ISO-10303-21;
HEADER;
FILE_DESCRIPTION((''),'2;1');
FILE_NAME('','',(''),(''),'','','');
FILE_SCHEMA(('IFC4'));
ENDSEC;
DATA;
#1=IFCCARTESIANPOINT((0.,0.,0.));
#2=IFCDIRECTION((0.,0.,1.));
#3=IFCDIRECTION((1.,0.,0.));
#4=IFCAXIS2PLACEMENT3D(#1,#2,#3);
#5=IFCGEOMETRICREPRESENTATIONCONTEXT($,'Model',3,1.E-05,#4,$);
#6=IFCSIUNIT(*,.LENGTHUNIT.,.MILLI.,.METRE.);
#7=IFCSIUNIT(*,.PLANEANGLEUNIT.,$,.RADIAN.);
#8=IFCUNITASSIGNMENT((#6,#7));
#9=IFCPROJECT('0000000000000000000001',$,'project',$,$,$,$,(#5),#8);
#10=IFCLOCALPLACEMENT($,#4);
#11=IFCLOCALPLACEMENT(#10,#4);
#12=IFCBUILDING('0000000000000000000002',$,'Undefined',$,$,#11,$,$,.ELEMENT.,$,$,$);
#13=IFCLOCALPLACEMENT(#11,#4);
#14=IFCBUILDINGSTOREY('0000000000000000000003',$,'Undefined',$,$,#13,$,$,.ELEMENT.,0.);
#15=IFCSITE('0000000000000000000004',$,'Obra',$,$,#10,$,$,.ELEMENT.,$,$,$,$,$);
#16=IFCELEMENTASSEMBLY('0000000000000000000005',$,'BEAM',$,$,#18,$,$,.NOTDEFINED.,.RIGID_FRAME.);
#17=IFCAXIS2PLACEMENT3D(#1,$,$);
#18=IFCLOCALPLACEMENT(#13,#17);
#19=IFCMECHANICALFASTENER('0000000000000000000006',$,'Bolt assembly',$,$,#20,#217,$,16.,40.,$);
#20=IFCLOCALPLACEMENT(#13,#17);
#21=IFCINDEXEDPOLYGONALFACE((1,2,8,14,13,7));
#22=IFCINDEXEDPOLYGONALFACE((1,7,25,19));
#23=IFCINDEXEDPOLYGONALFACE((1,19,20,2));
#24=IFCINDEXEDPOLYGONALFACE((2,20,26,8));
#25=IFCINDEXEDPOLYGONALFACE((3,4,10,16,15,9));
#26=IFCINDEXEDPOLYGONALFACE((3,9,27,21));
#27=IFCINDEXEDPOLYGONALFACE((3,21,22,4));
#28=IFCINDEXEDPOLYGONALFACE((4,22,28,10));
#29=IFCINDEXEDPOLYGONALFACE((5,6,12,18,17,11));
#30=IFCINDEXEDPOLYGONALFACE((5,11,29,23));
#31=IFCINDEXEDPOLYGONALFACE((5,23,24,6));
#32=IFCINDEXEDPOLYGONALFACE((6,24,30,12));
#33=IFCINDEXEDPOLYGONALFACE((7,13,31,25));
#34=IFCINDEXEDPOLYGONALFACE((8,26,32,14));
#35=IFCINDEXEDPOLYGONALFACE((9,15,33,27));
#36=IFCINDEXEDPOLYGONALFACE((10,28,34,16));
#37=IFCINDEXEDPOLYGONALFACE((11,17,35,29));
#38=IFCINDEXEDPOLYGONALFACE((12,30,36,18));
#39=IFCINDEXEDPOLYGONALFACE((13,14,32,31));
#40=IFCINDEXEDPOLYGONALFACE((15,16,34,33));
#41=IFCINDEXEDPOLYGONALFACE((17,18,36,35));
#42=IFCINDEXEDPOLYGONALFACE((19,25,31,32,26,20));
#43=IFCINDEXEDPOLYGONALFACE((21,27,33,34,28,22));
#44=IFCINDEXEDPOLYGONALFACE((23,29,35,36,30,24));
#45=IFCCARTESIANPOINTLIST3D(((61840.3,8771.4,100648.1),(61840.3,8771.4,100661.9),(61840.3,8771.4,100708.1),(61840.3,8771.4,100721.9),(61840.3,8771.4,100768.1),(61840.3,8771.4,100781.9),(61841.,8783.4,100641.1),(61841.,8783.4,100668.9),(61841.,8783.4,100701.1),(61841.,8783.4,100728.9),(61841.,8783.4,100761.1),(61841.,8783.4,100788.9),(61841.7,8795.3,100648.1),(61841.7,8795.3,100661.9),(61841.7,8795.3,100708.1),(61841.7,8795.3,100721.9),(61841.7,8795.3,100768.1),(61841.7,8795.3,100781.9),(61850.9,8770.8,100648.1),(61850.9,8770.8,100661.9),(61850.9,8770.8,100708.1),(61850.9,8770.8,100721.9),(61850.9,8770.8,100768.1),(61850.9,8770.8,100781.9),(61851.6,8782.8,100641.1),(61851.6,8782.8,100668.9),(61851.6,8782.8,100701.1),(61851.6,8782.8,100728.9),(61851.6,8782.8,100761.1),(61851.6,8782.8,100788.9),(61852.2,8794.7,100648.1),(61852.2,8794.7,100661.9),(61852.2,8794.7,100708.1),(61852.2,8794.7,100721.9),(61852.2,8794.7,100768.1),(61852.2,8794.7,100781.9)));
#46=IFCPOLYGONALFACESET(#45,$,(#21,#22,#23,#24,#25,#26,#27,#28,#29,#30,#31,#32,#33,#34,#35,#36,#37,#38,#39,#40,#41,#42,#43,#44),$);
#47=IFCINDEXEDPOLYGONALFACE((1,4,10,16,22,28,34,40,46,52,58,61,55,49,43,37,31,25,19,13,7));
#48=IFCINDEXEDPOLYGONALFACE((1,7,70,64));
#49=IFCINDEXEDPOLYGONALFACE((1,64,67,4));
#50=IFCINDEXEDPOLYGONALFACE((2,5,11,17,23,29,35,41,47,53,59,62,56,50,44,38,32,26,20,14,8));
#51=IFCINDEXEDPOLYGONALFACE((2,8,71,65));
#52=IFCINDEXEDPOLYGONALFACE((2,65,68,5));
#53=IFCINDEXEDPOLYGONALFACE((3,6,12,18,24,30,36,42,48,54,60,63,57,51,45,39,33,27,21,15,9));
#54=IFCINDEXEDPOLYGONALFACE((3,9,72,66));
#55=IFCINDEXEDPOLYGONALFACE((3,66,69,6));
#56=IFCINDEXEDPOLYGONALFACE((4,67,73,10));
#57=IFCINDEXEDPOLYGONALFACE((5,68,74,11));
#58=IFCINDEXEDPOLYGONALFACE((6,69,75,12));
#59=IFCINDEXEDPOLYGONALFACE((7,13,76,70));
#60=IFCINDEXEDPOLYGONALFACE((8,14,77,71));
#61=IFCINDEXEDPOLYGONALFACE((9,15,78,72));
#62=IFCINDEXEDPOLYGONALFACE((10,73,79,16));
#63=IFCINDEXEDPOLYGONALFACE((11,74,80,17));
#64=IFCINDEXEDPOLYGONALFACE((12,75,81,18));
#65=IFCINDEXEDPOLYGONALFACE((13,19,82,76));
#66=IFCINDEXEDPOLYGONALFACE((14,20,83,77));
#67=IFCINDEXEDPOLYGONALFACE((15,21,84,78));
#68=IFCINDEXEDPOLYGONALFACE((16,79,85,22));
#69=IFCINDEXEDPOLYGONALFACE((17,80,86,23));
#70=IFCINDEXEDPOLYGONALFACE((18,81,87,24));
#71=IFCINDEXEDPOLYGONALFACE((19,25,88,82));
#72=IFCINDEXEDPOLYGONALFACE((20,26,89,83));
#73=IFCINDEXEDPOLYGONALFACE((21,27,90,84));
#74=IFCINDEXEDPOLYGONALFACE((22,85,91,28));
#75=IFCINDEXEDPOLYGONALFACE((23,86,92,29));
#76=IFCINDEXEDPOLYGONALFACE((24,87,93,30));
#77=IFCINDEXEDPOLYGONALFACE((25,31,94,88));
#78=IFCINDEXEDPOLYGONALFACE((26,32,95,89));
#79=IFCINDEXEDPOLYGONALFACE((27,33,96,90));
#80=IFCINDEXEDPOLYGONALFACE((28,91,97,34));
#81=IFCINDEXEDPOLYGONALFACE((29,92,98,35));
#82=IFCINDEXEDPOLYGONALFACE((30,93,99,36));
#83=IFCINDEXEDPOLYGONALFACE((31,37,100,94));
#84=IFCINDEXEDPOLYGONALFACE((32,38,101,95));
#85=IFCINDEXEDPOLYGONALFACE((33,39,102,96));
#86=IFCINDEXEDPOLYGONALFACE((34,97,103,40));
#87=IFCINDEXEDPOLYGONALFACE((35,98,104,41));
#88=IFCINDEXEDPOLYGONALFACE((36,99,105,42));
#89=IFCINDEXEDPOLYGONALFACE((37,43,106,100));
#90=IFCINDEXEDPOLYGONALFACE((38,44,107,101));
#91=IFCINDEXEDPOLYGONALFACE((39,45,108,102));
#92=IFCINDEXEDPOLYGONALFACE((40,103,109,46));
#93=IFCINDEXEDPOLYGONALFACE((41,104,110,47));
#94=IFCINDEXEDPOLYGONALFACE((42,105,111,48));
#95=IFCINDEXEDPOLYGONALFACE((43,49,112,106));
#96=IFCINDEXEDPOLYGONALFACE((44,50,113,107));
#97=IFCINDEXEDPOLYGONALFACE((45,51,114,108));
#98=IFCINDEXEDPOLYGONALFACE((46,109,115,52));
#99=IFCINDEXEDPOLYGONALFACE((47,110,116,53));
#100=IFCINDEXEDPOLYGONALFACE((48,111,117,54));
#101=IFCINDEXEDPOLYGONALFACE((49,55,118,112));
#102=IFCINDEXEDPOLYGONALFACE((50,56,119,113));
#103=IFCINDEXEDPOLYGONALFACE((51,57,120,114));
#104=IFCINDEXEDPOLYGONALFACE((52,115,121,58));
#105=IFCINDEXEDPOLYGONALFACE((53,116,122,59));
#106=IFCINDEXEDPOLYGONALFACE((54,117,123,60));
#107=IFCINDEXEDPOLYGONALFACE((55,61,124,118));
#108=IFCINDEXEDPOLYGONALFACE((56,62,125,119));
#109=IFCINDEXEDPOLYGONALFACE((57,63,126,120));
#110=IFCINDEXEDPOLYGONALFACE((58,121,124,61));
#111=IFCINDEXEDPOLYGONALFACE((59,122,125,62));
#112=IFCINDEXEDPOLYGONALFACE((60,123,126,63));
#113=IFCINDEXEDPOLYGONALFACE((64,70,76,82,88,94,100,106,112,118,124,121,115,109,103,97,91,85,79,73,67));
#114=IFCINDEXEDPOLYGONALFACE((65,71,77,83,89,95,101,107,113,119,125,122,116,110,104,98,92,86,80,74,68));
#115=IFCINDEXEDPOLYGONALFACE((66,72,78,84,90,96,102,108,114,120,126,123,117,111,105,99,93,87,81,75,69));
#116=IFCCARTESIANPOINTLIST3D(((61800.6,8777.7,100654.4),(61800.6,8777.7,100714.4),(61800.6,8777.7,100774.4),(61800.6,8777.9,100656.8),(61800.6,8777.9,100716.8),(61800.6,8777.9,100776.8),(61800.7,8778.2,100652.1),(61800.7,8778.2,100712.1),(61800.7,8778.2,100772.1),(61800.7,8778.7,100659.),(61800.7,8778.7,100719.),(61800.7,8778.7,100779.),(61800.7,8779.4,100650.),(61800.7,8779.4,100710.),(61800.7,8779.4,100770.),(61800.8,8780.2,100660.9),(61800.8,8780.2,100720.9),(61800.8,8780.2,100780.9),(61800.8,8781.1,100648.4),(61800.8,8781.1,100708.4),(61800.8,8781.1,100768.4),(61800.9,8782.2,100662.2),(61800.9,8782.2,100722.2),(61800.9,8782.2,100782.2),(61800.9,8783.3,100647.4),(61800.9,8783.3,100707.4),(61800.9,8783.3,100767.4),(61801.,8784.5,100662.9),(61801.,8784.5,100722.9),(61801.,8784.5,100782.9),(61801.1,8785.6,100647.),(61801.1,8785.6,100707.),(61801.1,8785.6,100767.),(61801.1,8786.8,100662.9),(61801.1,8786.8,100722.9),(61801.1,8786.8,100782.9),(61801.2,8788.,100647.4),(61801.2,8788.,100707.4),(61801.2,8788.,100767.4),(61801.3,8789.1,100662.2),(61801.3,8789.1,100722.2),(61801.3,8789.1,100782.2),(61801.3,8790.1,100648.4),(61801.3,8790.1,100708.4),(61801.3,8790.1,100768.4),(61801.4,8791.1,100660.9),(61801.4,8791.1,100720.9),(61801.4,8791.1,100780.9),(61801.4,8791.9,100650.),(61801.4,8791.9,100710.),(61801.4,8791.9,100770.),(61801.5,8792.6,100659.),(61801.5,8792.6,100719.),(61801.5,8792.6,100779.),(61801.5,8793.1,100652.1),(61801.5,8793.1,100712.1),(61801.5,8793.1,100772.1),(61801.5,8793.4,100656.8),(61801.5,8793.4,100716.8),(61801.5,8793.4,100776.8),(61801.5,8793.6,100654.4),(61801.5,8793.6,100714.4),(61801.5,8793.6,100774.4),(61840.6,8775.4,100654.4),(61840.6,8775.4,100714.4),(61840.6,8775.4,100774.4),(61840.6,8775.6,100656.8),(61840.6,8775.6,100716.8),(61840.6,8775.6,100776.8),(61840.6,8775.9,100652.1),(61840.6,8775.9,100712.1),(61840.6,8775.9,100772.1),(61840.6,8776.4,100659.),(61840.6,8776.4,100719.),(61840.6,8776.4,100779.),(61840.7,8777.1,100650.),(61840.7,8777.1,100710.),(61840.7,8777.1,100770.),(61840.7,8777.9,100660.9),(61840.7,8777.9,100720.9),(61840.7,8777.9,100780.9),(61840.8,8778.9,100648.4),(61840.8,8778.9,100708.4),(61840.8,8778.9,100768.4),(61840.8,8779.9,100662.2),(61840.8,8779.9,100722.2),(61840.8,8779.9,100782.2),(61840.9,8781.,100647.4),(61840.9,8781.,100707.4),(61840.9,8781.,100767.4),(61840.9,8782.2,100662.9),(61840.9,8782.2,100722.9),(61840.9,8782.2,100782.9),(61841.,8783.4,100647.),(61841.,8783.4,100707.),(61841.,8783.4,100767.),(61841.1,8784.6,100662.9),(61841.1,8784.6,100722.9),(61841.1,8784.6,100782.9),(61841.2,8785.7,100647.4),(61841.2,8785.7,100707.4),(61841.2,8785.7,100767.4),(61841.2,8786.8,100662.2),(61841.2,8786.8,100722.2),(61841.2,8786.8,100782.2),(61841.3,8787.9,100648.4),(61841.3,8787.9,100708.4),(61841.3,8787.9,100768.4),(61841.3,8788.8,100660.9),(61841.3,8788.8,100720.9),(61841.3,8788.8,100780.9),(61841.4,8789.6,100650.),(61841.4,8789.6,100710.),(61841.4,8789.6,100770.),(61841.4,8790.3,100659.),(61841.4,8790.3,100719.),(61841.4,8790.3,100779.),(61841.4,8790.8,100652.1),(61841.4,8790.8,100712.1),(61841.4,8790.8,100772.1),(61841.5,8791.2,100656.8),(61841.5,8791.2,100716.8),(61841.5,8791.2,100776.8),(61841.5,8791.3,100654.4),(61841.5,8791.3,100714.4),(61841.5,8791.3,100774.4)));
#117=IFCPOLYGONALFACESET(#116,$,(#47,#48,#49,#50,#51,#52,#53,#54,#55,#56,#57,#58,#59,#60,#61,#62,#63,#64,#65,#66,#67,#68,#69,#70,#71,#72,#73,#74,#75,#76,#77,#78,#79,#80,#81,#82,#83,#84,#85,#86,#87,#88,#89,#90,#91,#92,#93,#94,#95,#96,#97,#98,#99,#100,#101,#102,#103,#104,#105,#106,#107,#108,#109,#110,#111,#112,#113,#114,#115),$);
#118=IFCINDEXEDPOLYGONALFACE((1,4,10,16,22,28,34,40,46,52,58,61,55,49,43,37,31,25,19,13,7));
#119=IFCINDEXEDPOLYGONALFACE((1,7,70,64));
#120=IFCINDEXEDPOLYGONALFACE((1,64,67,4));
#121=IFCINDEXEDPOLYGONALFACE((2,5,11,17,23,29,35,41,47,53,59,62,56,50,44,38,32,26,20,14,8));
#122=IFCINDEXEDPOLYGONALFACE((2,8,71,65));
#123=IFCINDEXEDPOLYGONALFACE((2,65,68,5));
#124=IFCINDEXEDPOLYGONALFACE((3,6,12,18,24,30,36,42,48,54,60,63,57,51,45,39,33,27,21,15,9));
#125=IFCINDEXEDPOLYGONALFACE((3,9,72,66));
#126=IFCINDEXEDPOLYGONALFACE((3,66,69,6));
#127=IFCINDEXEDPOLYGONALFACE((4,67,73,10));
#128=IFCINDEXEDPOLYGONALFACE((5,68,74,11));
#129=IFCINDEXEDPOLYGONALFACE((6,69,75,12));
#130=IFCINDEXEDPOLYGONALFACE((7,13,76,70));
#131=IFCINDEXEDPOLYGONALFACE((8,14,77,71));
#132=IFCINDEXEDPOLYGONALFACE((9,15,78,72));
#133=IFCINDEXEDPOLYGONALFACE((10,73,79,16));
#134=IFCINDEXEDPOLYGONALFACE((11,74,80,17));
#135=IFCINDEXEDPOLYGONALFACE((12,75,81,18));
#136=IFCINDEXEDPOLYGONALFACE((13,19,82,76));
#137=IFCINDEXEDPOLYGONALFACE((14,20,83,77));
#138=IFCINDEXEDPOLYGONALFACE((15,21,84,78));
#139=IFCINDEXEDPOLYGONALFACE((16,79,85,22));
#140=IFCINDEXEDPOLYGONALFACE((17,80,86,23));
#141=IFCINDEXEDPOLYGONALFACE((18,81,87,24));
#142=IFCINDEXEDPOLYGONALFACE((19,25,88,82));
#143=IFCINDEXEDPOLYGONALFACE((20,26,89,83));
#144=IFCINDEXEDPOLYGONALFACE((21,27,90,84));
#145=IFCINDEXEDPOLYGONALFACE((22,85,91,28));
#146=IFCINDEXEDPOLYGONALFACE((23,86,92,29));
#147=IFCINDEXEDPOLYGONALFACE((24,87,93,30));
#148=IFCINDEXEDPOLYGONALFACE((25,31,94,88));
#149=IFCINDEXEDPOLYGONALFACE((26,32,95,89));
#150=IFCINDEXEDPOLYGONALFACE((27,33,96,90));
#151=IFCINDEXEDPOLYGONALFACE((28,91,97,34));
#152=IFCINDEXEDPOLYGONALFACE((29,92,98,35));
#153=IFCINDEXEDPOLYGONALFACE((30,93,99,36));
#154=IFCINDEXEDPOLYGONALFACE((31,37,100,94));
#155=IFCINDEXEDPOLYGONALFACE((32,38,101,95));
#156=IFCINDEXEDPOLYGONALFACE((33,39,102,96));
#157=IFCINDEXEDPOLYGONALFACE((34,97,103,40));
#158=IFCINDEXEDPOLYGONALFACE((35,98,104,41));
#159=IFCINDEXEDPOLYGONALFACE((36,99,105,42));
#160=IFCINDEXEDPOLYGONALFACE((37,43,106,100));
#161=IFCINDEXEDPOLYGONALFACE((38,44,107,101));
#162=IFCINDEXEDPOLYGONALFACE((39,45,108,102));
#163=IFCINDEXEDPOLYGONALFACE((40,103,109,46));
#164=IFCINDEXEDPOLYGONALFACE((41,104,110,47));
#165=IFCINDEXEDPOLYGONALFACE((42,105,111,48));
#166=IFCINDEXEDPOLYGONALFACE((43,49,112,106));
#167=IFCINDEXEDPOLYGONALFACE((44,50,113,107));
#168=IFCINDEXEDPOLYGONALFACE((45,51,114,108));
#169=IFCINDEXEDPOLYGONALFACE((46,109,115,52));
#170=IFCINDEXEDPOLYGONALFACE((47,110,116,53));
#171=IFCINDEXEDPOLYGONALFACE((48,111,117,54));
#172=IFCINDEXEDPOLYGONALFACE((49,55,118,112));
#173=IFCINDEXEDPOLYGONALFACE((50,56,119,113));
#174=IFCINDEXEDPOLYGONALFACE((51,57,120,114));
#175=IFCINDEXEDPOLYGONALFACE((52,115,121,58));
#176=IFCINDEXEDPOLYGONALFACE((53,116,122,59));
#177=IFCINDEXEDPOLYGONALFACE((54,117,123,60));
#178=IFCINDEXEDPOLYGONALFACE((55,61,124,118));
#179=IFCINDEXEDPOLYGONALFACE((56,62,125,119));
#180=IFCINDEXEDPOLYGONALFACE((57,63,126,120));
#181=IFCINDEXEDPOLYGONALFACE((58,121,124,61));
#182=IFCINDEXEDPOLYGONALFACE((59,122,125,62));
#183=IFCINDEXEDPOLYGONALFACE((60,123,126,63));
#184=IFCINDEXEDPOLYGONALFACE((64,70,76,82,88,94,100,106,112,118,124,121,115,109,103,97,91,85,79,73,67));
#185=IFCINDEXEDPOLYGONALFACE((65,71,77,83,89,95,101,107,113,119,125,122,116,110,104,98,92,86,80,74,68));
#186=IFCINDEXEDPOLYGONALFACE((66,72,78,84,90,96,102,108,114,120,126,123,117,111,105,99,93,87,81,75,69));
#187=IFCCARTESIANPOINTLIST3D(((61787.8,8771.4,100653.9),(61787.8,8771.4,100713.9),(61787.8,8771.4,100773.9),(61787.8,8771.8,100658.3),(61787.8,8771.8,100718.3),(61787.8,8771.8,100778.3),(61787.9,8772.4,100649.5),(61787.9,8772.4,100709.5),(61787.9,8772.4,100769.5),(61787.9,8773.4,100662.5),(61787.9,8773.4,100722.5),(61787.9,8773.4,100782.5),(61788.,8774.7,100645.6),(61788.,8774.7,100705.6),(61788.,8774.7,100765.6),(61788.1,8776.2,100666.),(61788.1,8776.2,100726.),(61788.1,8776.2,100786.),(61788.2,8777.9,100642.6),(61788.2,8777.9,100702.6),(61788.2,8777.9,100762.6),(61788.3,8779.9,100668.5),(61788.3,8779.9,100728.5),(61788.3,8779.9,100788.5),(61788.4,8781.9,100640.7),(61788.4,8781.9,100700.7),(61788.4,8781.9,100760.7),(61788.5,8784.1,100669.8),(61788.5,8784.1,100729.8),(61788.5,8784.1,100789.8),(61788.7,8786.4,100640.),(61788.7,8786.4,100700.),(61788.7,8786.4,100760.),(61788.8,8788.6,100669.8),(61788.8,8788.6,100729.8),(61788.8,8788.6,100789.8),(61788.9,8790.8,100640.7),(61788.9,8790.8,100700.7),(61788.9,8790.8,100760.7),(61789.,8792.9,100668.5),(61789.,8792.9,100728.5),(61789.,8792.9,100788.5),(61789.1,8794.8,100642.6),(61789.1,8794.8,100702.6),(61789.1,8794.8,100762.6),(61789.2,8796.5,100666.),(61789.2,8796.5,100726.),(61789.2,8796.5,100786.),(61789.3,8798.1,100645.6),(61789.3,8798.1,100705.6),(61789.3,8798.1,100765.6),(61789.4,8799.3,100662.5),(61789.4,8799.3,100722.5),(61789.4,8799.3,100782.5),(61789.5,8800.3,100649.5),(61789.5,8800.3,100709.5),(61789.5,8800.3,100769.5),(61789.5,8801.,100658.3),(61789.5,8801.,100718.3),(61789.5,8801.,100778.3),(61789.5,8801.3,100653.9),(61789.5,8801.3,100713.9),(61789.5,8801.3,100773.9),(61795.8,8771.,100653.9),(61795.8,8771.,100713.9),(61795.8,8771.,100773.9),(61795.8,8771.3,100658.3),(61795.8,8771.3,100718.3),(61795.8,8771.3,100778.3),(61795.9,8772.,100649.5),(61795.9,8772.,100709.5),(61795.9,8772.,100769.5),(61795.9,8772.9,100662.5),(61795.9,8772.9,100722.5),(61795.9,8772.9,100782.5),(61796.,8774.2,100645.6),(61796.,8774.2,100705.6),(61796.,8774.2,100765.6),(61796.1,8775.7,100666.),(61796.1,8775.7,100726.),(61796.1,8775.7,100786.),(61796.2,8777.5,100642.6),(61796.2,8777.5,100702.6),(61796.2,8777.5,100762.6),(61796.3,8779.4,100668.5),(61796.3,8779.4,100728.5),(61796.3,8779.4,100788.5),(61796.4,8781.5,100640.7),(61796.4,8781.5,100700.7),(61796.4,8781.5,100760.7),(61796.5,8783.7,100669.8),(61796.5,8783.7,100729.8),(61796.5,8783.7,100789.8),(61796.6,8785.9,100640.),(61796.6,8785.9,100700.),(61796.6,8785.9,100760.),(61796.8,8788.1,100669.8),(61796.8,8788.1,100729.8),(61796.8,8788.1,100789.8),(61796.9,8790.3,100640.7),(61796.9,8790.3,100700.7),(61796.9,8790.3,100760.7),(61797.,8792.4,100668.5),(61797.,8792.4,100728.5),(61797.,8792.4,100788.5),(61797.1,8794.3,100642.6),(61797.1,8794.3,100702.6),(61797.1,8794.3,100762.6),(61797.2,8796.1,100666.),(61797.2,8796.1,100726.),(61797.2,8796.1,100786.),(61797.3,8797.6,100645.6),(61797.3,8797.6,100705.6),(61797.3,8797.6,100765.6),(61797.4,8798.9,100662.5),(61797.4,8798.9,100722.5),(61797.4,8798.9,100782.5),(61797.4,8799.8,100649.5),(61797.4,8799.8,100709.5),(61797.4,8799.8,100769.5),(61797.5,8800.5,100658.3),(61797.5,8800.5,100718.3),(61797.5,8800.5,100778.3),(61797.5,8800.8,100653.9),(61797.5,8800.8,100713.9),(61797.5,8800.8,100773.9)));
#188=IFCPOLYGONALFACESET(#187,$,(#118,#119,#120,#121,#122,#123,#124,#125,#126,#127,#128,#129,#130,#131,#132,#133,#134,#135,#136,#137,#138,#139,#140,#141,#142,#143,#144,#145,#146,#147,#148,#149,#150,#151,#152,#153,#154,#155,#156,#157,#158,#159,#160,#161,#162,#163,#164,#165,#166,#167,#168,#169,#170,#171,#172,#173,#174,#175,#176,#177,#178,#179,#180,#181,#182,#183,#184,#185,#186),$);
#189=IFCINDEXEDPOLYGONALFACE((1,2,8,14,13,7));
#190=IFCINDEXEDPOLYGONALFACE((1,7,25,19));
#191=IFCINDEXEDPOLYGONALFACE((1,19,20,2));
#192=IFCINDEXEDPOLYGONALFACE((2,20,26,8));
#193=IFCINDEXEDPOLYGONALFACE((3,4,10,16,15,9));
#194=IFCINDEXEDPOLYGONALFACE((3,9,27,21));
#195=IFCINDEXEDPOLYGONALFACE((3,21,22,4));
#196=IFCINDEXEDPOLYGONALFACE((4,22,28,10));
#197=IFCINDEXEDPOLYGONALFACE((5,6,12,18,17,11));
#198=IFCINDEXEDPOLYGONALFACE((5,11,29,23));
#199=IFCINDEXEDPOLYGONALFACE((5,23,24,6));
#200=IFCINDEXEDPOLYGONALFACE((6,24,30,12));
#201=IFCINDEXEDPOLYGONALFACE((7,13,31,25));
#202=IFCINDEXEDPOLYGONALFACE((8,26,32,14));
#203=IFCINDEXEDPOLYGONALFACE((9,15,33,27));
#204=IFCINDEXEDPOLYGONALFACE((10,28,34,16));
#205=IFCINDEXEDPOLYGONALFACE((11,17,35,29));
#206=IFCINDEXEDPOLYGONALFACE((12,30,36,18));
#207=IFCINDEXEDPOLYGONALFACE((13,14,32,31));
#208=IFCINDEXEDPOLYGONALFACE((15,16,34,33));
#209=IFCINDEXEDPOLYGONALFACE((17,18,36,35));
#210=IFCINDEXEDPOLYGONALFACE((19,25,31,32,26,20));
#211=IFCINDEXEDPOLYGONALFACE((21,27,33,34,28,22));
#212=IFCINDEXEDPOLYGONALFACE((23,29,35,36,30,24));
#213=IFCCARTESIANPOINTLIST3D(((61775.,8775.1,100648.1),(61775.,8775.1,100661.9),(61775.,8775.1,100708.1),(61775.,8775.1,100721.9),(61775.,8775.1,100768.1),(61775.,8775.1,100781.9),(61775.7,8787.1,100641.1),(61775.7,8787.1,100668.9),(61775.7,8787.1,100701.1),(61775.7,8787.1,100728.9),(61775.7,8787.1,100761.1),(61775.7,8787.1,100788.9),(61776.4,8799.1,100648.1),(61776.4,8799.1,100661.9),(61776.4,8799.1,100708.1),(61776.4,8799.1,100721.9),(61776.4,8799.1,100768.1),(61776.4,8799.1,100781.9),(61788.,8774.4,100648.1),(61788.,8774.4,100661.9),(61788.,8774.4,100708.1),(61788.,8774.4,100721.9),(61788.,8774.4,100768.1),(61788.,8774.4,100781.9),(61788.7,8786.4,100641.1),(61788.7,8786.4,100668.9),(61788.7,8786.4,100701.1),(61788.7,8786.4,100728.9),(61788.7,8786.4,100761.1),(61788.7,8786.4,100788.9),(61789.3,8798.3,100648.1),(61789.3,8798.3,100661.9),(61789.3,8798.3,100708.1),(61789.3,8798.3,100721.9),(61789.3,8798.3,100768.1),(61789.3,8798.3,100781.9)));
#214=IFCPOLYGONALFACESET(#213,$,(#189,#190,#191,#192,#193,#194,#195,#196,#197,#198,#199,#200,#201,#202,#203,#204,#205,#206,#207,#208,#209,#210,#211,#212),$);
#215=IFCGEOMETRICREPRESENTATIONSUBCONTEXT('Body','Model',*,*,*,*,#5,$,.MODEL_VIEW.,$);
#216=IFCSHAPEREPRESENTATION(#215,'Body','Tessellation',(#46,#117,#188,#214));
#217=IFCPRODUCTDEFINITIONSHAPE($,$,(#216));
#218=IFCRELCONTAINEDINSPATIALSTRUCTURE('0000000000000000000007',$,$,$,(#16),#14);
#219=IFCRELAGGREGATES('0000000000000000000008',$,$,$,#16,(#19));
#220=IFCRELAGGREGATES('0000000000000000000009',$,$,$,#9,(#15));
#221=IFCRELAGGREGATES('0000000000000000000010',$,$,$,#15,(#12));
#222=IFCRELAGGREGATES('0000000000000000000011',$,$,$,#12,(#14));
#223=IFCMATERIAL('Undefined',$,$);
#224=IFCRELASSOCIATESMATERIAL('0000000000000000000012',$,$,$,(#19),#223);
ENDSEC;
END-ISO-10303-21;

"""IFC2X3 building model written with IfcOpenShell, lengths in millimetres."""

from ifc_helpers import new_model, si_unit, frame, origin_with_axes, origin_2d_with_axis, place, context, subcontext, project, spatial, polyline, circle, outline, extrude, source, transform, mapped, material, element, aggregate, save


model = new_model("IFC2X3")

# Units and contexts
model_context = context("Model", 3, precision=1e-05, world=origin_with_axes())
body_context = subcontext(model_context, "Body", "Model", "MODEL_VIEW")
ifc_project = project(units=[si_unit("LENGTHUNIT", "METRE", prefix="MILLI"), si_unit("PLANEANGLEUNIT", "RADIAN")], contexts=[model_context])

# Site, building, storey
site_placement = place(None, origin_with_axes())
site = spatial("IfcSite", under=ifc_project, at=site_placement, Name="Obra", CompositionType="ELEMENT")
building_placement = place(site_placement, origin_with_axes())
building = spatial("IfcBuilding", under=site, at=building_placement, Name="Undefined", CompositionType="ELEMENT")
storey_placement = place(building_placement, origin_with_axes())
storey = spatial("IfcBuildingStorey", under=building, at=storey_placement, Name="Undefined", CompositionType="ELEMENT", Elevation=0.0)

# Shared definitions
ifc_material_1 = material(Name="Undefined")

# Element assembly, mechanical fastener
shared_shape_1 = source(origin_with_axes(), body_context, "Body", "SweptSolid", [
    extrude(outline(polyline([(13.9, 0.0), (6.9, 12.0), (-6.9, 12.0), (-13.9, 0.0), (-6.9, -12.0), (6.9, -12.0), (13.9, 0.0)])), frame((0.0, -19.7, 0.0), z_axis=(0.0, 1.0, 0.0), x_axis=(1.0, 0.0, 0.0)), (0.0, 0.0, 1.0), 10.6),
    extrude(circle(Radius=8.0, at=origin_2d_with_axis()), frame((0.0, -9.1, 0.0), z_axis=(0.0, 1.0, 0.0), x_axis=(1.0, 0.0, 0.0)), (0.0, 0.0, 1.0), 40.0),
    extrude(circle(Radius=15.0, at=origin_2d_with_axis()), frame((0.0, 35.3, 0.0), z_axis=(0.0, 1.0, 0.0), x_axis=(1.0, 0.0, 0.0)), (0.0, 0.0, 1.0), 8.0),
    extrude(outline(polyline([(13.9, 0.0), (6.9, 12.0), (-6.9, 12.0), (-13.9, 0.0), (-6.9, -12.0), (6.9, -12.0), (13.9, 0.0)])), frame((0.0, 43.3, 0.0), z_axis=(0.0, 1.0, 0.0), x_axis=(1.0, 0.0, 0.0)), (0.0, 0.0, 1.0), 13.0),
])
assembly_1_placement = place(storey_placement, origin_with_axes())
assembly_1 = element("IfcElementAssembly", 1, at=assembly_1_placement, inside=storey, Name="BEAM", AssemblyPlace="NOTDEFINED", PredefinedType="RIGID_FRAME")
mechanical_fastener_1_placement = place(assembly_1_placement, frame((61829.1, 8734.0, 100835.0), z_axis=(0.05711, 0.998368, 0.0), x_axis=(0.0, 0.0, -1.0)))
mechanical_fastener_1 = element("IfcMechanicalFastener", 2, at=mechanical_fastener_1_placement, material=ifc_material_1, Name="Bolt assembly", NominalDiameter=16.0, NominalLength=40.0, context=body_context, shape_type="MappedRepresentation", body=[
    mapped(shared_shape_1, transform((60.0, 0.0, 50.0))),
    mapped(shared_shape_1, transform((120.0, 0.0, 50.0))),
    mapped(shared_shape_1, transform((180.0, 0.0, 50.0))),
])

aggregate(assembly_1, [mechanical_fastener_1])

save(model, "model.ifc")
